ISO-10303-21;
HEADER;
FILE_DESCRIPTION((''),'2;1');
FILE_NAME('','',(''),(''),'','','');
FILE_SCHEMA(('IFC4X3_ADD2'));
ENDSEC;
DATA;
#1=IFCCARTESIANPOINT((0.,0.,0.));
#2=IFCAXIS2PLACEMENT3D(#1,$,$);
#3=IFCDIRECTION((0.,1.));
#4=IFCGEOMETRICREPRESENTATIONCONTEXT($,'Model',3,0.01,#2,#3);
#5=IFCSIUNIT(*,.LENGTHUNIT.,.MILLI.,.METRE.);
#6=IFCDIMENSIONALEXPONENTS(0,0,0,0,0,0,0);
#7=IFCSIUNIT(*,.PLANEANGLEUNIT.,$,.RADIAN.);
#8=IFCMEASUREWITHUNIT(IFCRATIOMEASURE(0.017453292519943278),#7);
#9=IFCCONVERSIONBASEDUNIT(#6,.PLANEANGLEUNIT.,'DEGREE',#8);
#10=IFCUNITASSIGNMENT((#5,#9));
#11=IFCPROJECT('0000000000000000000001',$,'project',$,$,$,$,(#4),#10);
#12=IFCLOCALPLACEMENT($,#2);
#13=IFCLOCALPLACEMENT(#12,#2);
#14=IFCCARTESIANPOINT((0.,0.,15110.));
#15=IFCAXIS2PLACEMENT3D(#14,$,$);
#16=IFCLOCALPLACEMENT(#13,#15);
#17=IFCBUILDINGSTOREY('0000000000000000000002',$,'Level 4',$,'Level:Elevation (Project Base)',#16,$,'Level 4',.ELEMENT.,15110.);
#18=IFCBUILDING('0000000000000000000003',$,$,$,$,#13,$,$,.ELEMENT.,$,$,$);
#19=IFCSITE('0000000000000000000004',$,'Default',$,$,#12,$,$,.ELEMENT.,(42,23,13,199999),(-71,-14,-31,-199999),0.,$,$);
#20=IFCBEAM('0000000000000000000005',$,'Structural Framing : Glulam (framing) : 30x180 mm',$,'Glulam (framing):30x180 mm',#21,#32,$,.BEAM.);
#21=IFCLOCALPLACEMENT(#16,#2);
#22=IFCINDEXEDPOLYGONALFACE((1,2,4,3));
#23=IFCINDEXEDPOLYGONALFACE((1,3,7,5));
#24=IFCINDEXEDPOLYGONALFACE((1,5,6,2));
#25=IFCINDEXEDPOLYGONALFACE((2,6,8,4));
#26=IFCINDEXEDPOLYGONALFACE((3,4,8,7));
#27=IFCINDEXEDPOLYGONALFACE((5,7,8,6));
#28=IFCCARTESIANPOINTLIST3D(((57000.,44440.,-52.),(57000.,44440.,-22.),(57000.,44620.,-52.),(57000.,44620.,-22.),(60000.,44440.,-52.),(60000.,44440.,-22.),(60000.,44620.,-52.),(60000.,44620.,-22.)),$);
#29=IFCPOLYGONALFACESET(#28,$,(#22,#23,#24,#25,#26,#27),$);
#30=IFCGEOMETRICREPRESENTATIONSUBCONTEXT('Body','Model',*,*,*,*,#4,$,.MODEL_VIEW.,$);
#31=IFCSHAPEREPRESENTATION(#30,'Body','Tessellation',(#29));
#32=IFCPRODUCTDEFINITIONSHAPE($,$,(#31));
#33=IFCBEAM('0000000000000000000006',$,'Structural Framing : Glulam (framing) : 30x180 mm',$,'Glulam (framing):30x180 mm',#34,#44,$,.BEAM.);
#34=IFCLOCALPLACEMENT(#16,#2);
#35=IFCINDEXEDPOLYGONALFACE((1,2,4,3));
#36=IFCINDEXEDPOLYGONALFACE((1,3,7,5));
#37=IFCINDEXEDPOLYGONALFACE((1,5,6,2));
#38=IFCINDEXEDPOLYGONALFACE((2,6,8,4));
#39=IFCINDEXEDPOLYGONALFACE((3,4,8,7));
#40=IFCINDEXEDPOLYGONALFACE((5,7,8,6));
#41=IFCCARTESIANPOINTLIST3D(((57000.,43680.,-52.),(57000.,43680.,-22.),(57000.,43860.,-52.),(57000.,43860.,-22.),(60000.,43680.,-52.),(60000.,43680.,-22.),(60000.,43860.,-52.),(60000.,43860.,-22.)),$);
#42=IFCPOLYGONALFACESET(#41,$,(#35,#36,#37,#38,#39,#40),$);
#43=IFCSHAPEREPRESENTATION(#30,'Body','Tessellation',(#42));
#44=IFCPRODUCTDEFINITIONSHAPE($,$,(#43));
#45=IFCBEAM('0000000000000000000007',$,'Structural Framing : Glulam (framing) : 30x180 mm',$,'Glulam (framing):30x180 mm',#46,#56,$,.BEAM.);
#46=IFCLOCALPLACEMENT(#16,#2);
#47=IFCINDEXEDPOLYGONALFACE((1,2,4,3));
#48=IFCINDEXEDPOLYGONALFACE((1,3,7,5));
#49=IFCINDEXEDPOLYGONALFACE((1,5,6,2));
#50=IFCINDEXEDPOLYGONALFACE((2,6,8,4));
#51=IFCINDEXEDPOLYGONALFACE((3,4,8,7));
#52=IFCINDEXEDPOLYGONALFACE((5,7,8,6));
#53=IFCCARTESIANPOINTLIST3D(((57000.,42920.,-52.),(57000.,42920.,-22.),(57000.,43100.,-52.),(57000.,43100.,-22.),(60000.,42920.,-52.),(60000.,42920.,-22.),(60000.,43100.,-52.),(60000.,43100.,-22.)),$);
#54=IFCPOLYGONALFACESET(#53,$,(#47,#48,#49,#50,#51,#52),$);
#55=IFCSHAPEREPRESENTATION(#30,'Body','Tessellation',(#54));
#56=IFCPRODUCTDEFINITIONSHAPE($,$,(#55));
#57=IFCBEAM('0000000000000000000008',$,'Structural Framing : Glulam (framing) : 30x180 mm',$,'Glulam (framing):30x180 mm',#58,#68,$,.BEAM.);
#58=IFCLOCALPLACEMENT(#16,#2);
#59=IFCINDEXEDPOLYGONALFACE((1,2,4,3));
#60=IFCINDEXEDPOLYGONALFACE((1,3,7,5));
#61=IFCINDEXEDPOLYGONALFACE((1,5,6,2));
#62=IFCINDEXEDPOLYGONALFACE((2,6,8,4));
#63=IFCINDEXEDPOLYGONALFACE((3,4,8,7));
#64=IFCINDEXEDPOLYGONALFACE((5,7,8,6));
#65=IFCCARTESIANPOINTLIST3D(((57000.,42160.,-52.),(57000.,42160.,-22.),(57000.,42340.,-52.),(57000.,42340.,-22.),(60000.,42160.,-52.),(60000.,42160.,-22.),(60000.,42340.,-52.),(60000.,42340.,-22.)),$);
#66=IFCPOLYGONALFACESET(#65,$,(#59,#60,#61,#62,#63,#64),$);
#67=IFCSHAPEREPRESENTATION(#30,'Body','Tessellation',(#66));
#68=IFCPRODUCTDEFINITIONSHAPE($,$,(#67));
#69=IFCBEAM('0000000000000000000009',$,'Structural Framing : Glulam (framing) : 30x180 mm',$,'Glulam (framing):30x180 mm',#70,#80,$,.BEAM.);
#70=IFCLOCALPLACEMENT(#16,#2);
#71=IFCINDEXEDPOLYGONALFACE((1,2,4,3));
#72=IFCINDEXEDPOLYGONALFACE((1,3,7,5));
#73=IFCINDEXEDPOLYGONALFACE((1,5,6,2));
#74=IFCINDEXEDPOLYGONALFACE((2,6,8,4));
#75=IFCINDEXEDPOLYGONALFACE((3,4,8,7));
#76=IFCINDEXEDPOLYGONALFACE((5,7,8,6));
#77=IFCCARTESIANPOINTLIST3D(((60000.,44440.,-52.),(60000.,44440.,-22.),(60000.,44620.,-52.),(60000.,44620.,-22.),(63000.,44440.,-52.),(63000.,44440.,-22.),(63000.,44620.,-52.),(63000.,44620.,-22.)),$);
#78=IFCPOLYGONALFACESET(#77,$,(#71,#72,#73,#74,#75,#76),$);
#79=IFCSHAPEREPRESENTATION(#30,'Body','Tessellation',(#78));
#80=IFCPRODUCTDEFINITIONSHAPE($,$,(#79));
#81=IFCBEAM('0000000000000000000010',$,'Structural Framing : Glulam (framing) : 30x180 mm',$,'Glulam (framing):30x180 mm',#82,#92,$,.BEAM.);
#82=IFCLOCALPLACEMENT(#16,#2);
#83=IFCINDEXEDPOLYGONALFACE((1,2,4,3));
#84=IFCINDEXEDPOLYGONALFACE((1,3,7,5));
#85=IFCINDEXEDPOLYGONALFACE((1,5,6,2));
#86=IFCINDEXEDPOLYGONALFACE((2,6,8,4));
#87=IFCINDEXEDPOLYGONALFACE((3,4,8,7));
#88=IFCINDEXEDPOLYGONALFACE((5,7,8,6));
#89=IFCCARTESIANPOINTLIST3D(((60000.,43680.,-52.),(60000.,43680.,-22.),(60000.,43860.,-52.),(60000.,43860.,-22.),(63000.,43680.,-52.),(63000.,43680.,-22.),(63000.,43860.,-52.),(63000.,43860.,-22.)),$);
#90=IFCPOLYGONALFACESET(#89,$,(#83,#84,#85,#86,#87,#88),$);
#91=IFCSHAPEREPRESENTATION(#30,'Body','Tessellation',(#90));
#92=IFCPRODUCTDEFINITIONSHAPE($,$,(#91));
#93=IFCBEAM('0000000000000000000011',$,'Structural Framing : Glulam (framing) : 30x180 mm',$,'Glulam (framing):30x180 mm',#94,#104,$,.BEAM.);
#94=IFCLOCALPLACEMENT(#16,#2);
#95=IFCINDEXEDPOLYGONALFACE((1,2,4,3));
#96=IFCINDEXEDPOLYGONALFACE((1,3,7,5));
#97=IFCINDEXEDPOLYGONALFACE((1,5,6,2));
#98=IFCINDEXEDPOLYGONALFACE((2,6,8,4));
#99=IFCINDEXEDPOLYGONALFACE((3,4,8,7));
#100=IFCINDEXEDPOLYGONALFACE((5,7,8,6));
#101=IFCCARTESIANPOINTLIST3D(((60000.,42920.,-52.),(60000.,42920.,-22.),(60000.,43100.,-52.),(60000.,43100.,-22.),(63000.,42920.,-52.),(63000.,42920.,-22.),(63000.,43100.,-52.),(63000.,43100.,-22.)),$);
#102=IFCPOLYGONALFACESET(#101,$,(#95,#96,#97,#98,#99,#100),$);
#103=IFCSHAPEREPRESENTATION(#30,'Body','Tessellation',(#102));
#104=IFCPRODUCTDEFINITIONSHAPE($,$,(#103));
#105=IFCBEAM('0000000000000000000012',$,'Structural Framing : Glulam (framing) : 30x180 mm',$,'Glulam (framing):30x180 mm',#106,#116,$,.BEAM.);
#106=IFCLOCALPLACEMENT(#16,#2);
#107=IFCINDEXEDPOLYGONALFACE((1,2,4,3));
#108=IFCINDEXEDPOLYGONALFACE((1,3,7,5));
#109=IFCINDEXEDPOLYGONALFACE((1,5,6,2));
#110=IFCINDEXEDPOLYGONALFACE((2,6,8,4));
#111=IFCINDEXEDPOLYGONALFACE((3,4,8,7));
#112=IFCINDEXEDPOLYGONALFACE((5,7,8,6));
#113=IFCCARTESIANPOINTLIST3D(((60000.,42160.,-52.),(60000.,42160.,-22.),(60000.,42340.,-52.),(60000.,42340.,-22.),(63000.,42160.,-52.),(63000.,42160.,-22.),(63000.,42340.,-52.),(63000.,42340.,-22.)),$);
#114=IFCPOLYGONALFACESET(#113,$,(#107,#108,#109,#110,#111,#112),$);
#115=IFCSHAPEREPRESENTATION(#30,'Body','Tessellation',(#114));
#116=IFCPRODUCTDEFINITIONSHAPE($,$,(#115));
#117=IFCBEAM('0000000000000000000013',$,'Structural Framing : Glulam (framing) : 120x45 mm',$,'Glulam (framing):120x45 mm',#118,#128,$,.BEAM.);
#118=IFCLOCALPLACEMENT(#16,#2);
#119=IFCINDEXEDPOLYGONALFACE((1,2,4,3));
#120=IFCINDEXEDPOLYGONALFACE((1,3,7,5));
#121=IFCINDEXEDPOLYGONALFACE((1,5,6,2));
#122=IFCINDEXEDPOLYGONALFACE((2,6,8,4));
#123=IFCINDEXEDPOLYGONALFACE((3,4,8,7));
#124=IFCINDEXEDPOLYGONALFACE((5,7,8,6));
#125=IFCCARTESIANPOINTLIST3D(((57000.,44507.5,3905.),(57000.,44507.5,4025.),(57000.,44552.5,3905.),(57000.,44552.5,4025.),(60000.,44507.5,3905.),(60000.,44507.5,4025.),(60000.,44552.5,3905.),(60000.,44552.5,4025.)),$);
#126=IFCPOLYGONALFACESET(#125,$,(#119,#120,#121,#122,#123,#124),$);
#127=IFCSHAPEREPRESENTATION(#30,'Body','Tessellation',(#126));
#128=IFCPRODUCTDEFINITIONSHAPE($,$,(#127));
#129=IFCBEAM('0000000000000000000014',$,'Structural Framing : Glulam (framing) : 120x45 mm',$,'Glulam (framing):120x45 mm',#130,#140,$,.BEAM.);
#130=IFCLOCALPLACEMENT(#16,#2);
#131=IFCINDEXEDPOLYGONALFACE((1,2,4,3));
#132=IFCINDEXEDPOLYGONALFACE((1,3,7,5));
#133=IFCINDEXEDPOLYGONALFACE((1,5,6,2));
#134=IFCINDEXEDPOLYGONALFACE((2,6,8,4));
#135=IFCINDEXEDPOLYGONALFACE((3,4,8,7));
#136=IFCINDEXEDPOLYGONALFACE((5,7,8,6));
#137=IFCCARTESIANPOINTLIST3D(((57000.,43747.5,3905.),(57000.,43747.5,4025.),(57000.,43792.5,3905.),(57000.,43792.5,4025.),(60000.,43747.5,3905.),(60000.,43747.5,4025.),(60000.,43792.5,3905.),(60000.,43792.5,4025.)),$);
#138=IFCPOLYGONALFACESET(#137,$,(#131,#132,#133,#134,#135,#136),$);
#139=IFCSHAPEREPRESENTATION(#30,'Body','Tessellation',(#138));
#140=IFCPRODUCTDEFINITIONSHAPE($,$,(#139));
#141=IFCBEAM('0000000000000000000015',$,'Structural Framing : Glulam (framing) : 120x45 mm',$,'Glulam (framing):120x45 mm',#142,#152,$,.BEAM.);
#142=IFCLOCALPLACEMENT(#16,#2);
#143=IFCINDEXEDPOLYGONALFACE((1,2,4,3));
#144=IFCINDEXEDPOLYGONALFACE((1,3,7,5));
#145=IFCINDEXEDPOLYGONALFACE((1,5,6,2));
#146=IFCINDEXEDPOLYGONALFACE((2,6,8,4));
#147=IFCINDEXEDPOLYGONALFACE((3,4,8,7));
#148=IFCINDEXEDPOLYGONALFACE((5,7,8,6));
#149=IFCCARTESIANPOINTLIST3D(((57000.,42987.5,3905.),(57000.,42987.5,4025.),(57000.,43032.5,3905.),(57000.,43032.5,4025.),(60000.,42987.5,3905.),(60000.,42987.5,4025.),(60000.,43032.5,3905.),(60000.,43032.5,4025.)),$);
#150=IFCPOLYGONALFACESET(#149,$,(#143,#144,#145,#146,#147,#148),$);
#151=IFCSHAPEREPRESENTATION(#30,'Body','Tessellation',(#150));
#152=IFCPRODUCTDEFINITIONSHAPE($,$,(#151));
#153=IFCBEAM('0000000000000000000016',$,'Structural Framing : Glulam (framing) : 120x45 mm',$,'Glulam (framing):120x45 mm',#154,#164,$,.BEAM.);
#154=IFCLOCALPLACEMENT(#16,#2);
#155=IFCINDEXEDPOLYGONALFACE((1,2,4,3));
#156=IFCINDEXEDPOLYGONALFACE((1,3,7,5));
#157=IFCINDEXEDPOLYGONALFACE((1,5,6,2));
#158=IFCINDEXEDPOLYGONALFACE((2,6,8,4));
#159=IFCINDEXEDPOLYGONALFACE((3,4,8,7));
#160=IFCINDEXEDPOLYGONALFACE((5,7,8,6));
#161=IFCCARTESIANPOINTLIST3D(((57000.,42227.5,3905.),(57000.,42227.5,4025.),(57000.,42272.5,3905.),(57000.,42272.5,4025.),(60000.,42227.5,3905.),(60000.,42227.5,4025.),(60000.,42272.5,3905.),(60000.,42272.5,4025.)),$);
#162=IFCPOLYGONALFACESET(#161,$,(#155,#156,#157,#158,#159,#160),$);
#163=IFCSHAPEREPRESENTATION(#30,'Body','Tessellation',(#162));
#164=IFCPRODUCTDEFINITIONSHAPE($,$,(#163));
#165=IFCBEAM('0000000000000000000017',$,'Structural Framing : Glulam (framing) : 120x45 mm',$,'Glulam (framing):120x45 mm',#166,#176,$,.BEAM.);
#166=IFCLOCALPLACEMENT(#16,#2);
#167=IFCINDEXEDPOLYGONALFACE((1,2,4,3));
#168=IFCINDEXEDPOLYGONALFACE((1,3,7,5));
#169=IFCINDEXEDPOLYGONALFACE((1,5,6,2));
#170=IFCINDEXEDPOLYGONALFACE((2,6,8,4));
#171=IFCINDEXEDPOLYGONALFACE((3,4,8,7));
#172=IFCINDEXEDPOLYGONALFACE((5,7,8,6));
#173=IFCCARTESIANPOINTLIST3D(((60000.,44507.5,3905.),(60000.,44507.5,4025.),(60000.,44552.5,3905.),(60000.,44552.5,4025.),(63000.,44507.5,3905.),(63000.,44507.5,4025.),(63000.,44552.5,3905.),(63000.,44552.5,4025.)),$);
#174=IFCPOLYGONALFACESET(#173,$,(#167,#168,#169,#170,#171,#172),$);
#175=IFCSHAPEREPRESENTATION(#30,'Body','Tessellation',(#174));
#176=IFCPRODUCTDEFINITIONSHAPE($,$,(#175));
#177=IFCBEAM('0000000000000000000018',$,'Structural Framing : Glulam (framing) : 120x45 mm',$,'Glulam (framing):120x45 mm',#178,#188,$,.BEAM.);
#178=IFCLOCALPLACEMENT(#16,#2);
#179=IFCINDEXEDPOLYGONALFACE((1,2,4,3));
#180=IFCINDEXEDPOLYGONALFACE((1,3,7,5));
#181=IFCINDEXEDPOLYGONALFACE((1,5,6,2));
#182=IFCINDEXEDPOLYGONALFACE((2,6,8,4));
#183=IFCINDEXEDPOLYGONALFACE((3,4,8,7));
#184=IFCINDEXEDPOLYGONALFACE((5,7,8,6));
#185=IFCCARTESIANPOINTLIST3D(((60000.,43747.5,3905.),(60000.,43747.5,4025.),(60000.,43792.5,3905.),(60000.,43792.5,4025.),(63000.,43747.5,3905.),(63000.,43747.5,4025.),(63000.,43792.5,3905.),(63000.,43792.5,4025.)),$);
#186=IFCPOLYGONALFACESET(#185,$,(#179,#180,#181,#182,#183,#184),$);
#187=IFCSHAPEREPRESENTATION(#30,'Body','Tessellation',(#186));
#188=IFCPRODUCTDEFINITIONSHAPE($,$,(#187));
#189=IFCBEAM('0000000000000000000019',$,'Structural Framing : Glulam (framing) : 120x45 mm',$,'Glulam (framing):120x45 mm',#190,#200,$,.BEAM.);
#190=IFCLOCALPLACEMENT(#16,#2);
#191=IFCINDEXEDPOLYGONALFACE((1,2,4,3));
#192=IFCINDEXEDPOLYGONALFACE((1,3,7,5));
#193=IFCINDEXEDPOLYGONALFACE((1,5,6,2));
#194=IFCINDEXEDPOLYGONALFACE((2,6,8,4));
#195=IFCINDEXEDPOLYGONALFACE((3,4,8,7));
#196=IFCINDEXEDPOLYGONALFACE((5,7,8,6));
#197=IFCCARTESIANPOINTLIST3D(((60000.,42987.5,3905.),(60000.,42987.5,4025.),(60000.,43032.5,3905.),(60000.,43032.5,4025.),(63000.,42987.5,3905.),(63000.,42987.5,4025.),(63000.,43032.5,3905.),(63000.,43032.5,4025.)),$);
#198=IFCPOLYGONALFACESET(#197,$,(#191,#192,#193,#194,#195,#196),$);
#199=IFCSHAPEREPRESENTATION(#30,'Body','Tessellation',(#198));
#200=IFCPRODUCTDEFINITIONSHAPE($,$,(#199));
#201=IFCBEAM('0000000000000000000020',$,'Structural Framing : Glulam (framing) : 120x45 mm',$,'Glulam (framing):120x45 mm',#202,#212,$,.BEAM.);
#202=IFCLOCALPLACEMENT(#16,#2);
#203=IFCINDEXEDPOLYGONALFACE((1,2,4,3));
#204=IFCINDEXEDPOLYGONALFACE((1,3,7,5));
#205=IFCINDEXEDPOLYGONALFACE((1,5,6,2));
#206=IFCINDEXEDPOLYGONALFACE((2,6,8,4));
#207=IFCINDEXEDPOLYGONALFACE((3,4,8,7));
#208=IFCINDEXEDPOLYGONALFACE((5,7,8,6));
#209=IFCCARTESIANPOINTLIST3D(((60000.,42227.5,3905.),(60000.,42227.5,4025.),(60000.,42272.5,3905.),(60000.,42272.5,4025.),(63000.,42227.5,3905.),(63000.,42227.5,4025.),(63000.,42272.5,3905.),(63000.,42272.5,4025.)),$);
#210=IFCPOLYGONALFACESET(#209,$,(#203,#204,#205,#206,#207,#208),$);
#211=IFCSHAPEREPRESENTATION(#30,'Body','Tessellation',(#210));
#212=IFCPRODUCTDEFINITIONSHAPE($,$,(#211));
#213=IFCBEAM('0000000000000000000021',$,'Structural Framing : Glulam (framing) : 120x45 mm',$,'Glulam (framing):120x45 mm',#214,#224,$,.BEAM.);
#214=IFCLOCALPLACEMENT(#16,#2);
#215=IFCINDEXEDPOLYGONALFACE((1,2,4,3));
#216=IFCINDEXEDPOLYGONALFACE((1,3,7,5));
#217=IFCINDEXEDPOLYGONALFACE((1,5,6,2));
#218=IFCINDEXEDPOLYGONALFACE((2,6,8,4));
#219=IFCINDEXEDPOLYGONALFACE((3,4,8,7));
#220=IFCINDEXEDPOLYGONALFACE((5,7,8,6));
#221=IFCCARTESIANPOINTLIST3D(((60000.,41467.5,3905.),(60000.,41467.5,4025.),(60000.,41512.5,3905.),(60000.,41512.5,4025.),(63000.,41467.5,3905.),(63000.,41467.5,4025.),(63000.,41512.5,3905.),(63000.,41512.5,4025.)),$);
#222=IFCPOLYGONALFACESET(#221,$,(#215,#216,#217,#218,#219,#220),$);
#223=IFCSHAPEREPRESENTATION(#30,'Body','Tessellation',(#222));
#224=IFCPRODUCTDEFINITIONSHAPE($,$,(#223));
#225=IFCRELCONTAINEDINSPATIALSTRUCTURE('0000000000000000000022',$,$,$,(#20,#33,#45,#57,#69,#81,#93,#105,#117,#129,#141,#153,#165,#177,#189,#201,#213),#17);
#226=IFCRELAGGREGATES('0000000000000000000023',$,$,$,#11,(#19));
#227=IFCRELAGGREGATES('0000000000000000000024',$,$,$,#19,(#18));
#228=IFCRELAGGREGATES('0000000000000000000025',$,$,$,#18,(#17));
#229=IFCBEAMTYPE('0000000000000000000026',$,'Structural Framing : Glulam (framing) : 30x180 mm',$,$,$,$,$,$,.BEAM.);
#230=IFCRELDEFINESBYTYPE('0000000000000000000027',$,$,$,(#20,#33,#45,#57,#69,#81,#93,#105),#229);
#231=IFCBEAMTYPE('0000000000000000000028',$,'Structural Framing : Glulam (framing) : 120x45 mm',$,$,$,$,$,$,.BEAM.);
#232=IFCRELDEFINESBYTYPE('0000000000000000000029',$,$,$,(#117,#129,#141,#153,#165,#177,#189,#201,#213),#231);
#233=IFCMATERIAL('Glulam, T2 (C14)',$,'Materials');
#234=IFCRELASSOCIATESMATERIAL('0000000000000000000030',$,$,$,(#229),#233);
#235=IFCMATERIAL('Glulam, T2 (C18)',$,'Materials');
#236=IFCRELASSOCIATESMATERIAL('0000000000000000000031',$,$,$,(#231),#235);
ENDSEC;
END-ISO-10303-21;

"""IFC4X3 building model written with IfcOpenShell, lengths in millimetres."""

from ifc_helpers import new_model, entity, si_unit, converted_unit, direction, frame, origin, origin_2d_with_axis, place, context, subcontext, project, spatial, rectangle, extrude, source, transform, mapped, material, material_profile, profile_set, type_object, type_shapes, element, save


model = new_model("IFC4X3")

# Units and contexts
model_context = context("Model", 3, precision=0.01, world=origin(), true_north=direction((0.0, 1.0)))
body_context = subcontext(model_context, "Body", "Model", "MODEL_VIEW")
ifc_project = project(units=[si_unit("LENGTHUNIT", "METRE", prefix="MILLI"), converted_unit("PLANEANGLEUNIT", "DEGREE", entity("IfcRatioMeasure", 0.017453292519943278), si_unit("PLANEANGLEUNIT", "RADIAN"), dimensions=[0, 0, 0, 0, 0, 0, 0])], contexts=[model_context])

# Site, building, storey
site_placement = place(None, origin())
site = spatial("IfcSite", under=ifc_project, at=site_placement, Name="Default", CompositionType="ELEMENT", RefLatitude=(42, 23, 13, 199999), RefLongitude=(-71, -14, -31, -199999), RefElevation=0.0)
building_placement = place(site_placement, origin())
building = spatial("IfcBuilding", under=site, at=building_placement, CompositionType="ELEMENT")
storey_placement = place(building_placement, frame((0.0, 0.0, 15110.0)))
storey = spatial("IfcBuildingStorey", under=building, at=storey_placement, Name="Level 4", ObjectType="Level:Elevation (Project Base)", LongName="Level 4", CompositionType="ELEMENT", Elevation=15110.0)

# Beams
ifc_material_1 = material(Name="Glulam, T2 (C14)", Category="Materials")
ifc_material_profile_1 = material_profile(ifc_material_1, rectangle(XDim=30.0, YDim=180.0, at=origin_2d_with_axis()), Name="30x180 mm")
ifc_profile_set_1 = profile_set([ifc_material_profile_1], Name="30x180 mm")
beam_type_1 = type_object("IfcBeamType", Name="Structural Framing : Glulam (framing) : 30x180 mm", PredefinedType="BEAM", material=ifc_profile_set_1)
shared_shape_1 = source(origin(), body_context, "Body", "SweptSolid", [
    extrude(rectangle(XDim=30.0, YDim=180.0, at=origin_2d_with_axis()), frame((500.0, 0.0, 0.0), z_axis=(1.0, 0.0, 0.0), x_axis=(0.0, 0.0, -1.0)), (0.0, 0.0, 1.0), 3000.0),
])
type_shapes(beam_type_1, [shared_shape_1])
for number, where, name in (
    (1, (56500.0, 44530.0, -37.0), "Structural Framing : Glulam (framing) : 30x180 mm"),
    (2, (56500.0, 43770.0, -37.0), "Structural Framing : Glulam (framing) : 30x180 mm"),
    (3, (56500.0, 43010.0, -37.0), "Structural Framing : Glulam (framing) : 30x180 mm"),
    (4, (56500.0, 42250.0, -37.0), "Structural Framing : Glulam (framing) : 30x180 mm"),
    (5, (59500.0, 44530.0, -37.0), "Structural Framing : Glulam (framing) : 30x180 mm"),
    (6, (59500.0, 43770.0, -37.0), "Structural Framing : Glulam (framing) : 30x180 mm"),
    (7, (59500.0, 43010.0, -37.0), "Structural Framing : Glulam (framing) : 30x180 mm"),
    (8, (59500.0, 42250.0, -37.0), "Structural Framing : Glulam (framing) : 30x180 mm"),
):
    element("IfcBeam", number, at=place(storey_placement, frame(where)), inside=storey, type_object=beam_type_1, Name=name, ObjectType="Glulam (framing):30x180 mm", PredefinedType="BEAM", context=body_context, shape_type="MappedRepresentation", body=[
        mapped(shared_shape_1, transform((0.0, 0.0, 0.0), scale=1.0)),
    ])
ifc_material_2 = material(Name="Glulam, T2 (C18)", Category="Materials")
ifc_material_profile_2 = material_profile(ifc_material_2, rectangle(XDim=120.0, YDim=45.0, at=origin_2d_with_axis()), Name="120x45 mm")
ifc_profile_set_2 = profile_set([ifc_material_profile_2], Name="120x45 mm")
beam_type_2 = type_object("IfcBeamType", Name="Structural Framing : Glulam (framing) : 120x45 mm", PredefinedType="BEAM", material=ifc_profile_set_2)
shared_shape_2 = source(origin(), body_context, "Body", "SweptSolid", [
    extrude(rectangle(XDim=120.0, YDim=45.0, at=origin_2d_with_axis()), frame((500.0, 0.0, 0.0), z_axis=(1.0, 0.0, 0.0), x_axis=(0.0, 0.0, -1.0)), (0.0, 0.0, 1.0), 3000.0),
])
type_shapes(beam_type_2, [shared_shape_2])
for number, where, name in (
    (9, (56500.0, 44530.0, 3965.0), "Structural Framing : Glulam (framing) : 120x45 mm"),
    (10, (56500.0, 43770.0, 3965.0), "Structural Framing : Glulam (framing) : 120x45 mm"),
    (11, (56500.0, 43010.0, 3965.0), "Structural Framing : Glulam (framing) : 120x45 mm"),
    (12, (56500.0, 42250.0, 3965.0), "Structural Framing : Glulam (framing) : 120x45 mm"),
    (13, (59500.0, 44530.0, 3965.0), "Structural Framing : Glulam (framing) : 120x45 mm"),
    (14, (59500.0, 43770.0, 3965.0), "Structural Framing : Glulam (framing) : 120x45 mm"),
    (15, (59500.0, 43010.0, 3965.0), "Structural Framing : Glulam (framing) : 120x45 mm"),
    (16, (59500.0, 42250.0, 3965.0), "Structural Framing : Glulam (framing) : 120x45 mm"),
    (17, (59500.0, 41490.0, 3965.0), "Structural Framing : Glulam (framing) : 120x45 mm"),
):
    element("IfcBeam", number, at=place(storey_placement, frame(where)), inside=storey, type_object=beam_type_2, Name=name, ObjectType="Glulam (framing):120x45 mm", PredefinedType="BEAM", context=body_context, shape_type="MappedRepresentation", body=[
        mapped(shared_shape_2, transform((0.0, 0.0, 0.0), scale=1.0)),
    ])

save(model, "model.ifc")
